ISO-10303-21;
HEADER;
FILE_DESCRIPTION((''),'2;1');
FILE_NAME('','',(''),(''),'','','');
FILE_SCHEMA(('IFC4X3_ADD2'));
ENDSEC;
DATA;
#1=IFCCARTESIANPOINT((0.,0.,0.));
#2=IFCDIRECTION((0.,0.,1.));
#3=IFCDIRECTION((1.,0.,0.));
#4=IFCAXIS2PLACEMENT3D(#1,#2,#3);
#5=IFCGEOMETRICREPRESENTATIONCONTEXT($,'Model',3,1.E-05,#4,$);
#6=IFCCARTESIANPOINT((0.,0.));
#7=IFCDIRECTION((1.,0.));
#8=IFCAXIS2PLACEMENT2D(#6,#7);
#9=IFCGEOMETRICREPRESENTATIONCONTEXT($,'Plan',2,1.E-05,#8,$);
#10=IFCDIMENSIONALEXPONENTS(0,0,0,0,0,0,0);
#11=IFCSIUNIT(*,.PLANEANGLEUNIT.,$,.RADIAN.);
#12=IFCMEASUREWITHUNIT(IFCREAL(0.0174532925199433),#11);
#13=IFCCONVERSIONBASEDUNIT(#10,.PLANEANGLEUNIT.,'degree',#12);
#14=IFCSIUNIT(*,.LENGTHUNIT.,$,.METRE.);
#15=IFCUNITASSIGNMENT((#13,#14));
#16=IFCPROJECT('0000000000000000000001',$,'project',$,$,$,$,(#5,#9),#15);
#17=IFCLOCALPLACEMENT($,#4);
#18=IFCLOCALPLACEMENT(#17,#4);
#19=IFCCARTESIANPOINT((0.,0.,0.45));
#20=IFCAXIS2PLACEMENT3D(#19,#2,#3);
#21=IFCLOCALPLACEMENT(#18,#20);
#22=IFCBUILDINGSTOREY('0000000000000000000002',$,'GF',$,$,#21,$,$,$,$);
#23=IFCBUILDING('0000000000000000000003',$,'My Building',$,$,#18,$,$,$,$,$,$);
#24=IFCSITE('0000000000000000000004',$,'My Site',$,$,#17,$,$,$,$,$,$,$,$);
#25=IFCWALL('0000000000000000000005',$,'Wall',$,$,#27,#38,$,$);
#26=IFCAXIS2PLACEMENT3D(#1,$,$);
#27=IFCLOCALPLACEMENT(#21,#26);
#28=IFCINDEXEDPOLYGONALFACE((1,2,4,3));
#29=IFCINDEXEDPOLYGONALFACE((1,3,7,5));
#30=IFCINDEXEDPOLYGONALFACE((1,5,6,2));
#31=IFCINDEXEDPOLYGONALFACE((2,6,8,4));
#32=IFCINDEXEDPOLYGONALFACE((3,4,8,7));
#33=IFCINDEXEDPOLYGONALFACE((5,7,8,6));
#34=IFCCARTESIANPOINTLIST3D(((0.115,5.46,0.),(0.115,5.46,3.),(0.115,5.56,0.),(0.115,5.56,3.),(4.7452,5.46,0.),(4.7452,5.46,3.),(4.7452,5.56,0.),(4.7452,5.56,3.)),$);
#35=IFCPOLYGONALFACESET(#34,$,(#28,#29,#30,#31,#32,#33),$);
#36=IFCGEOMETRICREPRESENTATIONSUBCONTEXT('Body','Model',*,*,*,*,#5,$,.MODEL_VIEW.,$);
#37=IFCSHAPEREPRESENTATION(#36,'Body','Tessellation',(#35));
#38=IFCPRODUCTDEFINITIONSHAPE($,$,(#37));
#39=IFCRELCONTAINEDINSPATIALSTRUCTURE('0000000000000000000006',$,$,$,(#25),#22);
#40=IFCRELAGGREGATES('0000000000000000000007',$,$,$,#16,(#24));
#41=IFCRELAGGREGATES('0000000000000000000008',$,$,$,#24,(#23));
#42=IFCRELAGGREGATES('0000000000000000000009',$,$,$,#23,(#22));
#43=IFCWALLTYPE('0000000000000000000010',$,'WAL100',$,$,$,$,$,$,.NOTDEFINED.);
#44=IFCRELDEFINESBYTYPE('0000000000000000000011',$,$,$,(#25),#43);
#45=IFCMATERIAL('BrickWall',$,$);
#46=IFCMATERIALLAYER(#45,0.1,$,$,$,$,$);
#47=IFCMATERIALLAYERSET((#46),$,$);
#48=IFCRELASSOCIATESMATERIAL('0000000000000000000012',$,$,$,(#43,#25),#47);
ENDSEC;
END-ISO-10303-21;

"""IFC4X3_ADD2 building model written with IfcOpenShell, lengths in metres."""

from ifc_helpers import new_model, entity, si_unit, converted_unit, frame, origin_with_axes, origin_2d_with_axis, place, context, subcontext, project, spatial, indexed_curve, outline, extrude, material, layer, layer_set, layer_usage, type_object, element, save


model = new_model("IFC4X3_ADD2")

# Units and contexts
model_context = context("Model", 3, precision=1e-05, world=origin_with_axes())
plan_context = context("Plan", 2, precision=1e-05, world=origin_2d_with_axis())
body_context_1 = subcontext(model_context, "Body", "Model", "MODEL_VIEW")
ifc_project = project(units=[converted_unit("PLANEANGLEUNIT", "degree", entity("IfcReal", 0.0174532925199433), si_unit("PLANEANGLEUNIT", "RADIAN"), dimensions=[0, 0, 0, 0, 0, 0, 0]), si_unit("LENGTHUNIT", "METRE")], contexts=[model_context, plan_context])

# Site, building, storey
site_placement = place(None, origin_with_axes())
site = spatial("IfcSite", under=ifc_project, at=site_placement, Name="My Site")
building_placement = place(site_placement, origin_with_axes())
building = spatial("IfcBuilding", under=site, at=building_placement, Name="My Building")
storey_placement = place(building_placement, frame((0.0, 0.0, 0.45), z_axis=(0.0, 0.0, 1.0), x_axis=(1.0, 0.0, 0.0)))
storey = spatial("IfcBuildingStorey", under=building, at=storey_placement, Name="GF")

# Shared definitions
ifc_material_1 = material(Name="BrickWall")

# Wall
ifc_layer_1 = layer(ifc_material_1, 0.1)
ifc_layer_set_1 = layer_set([ifc_layer_1])
wall_type_1 = type_object("IfcWallType", Name="WAL100", PredefinedType="NOTDEFINED", material=ifc_layer_set_1)
ifc_layer_usage_1 = layer_usage(ifc_layer_set_1, "AXIS2", "POSITIVE", 0.0)
wall_1_placement = place(storey_placement, frame((0.115, 5.46, 0.0), z_axis=(0.0, 0.0, 1.0), x_axis=(1.0, 0.0, 0.0)))
element("IfcWall", 1, at=wall_1_placement, inside=storey, type_object=wall_type_1, material=ifc_layer_usage_1, Name="Wall", context=body_context_1, shape_type="SweptSolid", body=[
    extrude(outline(indexed_curve([(0.0, 0.0), (0.0, 0.1), (4.6302, 0.1), (4.6302, 0.0), (0.0, 0.0)], self_intersect=False)), origin_with_axes(), (0.0, 0.0, 1.0), 3.0),
])

save(model, "model.ifc")
